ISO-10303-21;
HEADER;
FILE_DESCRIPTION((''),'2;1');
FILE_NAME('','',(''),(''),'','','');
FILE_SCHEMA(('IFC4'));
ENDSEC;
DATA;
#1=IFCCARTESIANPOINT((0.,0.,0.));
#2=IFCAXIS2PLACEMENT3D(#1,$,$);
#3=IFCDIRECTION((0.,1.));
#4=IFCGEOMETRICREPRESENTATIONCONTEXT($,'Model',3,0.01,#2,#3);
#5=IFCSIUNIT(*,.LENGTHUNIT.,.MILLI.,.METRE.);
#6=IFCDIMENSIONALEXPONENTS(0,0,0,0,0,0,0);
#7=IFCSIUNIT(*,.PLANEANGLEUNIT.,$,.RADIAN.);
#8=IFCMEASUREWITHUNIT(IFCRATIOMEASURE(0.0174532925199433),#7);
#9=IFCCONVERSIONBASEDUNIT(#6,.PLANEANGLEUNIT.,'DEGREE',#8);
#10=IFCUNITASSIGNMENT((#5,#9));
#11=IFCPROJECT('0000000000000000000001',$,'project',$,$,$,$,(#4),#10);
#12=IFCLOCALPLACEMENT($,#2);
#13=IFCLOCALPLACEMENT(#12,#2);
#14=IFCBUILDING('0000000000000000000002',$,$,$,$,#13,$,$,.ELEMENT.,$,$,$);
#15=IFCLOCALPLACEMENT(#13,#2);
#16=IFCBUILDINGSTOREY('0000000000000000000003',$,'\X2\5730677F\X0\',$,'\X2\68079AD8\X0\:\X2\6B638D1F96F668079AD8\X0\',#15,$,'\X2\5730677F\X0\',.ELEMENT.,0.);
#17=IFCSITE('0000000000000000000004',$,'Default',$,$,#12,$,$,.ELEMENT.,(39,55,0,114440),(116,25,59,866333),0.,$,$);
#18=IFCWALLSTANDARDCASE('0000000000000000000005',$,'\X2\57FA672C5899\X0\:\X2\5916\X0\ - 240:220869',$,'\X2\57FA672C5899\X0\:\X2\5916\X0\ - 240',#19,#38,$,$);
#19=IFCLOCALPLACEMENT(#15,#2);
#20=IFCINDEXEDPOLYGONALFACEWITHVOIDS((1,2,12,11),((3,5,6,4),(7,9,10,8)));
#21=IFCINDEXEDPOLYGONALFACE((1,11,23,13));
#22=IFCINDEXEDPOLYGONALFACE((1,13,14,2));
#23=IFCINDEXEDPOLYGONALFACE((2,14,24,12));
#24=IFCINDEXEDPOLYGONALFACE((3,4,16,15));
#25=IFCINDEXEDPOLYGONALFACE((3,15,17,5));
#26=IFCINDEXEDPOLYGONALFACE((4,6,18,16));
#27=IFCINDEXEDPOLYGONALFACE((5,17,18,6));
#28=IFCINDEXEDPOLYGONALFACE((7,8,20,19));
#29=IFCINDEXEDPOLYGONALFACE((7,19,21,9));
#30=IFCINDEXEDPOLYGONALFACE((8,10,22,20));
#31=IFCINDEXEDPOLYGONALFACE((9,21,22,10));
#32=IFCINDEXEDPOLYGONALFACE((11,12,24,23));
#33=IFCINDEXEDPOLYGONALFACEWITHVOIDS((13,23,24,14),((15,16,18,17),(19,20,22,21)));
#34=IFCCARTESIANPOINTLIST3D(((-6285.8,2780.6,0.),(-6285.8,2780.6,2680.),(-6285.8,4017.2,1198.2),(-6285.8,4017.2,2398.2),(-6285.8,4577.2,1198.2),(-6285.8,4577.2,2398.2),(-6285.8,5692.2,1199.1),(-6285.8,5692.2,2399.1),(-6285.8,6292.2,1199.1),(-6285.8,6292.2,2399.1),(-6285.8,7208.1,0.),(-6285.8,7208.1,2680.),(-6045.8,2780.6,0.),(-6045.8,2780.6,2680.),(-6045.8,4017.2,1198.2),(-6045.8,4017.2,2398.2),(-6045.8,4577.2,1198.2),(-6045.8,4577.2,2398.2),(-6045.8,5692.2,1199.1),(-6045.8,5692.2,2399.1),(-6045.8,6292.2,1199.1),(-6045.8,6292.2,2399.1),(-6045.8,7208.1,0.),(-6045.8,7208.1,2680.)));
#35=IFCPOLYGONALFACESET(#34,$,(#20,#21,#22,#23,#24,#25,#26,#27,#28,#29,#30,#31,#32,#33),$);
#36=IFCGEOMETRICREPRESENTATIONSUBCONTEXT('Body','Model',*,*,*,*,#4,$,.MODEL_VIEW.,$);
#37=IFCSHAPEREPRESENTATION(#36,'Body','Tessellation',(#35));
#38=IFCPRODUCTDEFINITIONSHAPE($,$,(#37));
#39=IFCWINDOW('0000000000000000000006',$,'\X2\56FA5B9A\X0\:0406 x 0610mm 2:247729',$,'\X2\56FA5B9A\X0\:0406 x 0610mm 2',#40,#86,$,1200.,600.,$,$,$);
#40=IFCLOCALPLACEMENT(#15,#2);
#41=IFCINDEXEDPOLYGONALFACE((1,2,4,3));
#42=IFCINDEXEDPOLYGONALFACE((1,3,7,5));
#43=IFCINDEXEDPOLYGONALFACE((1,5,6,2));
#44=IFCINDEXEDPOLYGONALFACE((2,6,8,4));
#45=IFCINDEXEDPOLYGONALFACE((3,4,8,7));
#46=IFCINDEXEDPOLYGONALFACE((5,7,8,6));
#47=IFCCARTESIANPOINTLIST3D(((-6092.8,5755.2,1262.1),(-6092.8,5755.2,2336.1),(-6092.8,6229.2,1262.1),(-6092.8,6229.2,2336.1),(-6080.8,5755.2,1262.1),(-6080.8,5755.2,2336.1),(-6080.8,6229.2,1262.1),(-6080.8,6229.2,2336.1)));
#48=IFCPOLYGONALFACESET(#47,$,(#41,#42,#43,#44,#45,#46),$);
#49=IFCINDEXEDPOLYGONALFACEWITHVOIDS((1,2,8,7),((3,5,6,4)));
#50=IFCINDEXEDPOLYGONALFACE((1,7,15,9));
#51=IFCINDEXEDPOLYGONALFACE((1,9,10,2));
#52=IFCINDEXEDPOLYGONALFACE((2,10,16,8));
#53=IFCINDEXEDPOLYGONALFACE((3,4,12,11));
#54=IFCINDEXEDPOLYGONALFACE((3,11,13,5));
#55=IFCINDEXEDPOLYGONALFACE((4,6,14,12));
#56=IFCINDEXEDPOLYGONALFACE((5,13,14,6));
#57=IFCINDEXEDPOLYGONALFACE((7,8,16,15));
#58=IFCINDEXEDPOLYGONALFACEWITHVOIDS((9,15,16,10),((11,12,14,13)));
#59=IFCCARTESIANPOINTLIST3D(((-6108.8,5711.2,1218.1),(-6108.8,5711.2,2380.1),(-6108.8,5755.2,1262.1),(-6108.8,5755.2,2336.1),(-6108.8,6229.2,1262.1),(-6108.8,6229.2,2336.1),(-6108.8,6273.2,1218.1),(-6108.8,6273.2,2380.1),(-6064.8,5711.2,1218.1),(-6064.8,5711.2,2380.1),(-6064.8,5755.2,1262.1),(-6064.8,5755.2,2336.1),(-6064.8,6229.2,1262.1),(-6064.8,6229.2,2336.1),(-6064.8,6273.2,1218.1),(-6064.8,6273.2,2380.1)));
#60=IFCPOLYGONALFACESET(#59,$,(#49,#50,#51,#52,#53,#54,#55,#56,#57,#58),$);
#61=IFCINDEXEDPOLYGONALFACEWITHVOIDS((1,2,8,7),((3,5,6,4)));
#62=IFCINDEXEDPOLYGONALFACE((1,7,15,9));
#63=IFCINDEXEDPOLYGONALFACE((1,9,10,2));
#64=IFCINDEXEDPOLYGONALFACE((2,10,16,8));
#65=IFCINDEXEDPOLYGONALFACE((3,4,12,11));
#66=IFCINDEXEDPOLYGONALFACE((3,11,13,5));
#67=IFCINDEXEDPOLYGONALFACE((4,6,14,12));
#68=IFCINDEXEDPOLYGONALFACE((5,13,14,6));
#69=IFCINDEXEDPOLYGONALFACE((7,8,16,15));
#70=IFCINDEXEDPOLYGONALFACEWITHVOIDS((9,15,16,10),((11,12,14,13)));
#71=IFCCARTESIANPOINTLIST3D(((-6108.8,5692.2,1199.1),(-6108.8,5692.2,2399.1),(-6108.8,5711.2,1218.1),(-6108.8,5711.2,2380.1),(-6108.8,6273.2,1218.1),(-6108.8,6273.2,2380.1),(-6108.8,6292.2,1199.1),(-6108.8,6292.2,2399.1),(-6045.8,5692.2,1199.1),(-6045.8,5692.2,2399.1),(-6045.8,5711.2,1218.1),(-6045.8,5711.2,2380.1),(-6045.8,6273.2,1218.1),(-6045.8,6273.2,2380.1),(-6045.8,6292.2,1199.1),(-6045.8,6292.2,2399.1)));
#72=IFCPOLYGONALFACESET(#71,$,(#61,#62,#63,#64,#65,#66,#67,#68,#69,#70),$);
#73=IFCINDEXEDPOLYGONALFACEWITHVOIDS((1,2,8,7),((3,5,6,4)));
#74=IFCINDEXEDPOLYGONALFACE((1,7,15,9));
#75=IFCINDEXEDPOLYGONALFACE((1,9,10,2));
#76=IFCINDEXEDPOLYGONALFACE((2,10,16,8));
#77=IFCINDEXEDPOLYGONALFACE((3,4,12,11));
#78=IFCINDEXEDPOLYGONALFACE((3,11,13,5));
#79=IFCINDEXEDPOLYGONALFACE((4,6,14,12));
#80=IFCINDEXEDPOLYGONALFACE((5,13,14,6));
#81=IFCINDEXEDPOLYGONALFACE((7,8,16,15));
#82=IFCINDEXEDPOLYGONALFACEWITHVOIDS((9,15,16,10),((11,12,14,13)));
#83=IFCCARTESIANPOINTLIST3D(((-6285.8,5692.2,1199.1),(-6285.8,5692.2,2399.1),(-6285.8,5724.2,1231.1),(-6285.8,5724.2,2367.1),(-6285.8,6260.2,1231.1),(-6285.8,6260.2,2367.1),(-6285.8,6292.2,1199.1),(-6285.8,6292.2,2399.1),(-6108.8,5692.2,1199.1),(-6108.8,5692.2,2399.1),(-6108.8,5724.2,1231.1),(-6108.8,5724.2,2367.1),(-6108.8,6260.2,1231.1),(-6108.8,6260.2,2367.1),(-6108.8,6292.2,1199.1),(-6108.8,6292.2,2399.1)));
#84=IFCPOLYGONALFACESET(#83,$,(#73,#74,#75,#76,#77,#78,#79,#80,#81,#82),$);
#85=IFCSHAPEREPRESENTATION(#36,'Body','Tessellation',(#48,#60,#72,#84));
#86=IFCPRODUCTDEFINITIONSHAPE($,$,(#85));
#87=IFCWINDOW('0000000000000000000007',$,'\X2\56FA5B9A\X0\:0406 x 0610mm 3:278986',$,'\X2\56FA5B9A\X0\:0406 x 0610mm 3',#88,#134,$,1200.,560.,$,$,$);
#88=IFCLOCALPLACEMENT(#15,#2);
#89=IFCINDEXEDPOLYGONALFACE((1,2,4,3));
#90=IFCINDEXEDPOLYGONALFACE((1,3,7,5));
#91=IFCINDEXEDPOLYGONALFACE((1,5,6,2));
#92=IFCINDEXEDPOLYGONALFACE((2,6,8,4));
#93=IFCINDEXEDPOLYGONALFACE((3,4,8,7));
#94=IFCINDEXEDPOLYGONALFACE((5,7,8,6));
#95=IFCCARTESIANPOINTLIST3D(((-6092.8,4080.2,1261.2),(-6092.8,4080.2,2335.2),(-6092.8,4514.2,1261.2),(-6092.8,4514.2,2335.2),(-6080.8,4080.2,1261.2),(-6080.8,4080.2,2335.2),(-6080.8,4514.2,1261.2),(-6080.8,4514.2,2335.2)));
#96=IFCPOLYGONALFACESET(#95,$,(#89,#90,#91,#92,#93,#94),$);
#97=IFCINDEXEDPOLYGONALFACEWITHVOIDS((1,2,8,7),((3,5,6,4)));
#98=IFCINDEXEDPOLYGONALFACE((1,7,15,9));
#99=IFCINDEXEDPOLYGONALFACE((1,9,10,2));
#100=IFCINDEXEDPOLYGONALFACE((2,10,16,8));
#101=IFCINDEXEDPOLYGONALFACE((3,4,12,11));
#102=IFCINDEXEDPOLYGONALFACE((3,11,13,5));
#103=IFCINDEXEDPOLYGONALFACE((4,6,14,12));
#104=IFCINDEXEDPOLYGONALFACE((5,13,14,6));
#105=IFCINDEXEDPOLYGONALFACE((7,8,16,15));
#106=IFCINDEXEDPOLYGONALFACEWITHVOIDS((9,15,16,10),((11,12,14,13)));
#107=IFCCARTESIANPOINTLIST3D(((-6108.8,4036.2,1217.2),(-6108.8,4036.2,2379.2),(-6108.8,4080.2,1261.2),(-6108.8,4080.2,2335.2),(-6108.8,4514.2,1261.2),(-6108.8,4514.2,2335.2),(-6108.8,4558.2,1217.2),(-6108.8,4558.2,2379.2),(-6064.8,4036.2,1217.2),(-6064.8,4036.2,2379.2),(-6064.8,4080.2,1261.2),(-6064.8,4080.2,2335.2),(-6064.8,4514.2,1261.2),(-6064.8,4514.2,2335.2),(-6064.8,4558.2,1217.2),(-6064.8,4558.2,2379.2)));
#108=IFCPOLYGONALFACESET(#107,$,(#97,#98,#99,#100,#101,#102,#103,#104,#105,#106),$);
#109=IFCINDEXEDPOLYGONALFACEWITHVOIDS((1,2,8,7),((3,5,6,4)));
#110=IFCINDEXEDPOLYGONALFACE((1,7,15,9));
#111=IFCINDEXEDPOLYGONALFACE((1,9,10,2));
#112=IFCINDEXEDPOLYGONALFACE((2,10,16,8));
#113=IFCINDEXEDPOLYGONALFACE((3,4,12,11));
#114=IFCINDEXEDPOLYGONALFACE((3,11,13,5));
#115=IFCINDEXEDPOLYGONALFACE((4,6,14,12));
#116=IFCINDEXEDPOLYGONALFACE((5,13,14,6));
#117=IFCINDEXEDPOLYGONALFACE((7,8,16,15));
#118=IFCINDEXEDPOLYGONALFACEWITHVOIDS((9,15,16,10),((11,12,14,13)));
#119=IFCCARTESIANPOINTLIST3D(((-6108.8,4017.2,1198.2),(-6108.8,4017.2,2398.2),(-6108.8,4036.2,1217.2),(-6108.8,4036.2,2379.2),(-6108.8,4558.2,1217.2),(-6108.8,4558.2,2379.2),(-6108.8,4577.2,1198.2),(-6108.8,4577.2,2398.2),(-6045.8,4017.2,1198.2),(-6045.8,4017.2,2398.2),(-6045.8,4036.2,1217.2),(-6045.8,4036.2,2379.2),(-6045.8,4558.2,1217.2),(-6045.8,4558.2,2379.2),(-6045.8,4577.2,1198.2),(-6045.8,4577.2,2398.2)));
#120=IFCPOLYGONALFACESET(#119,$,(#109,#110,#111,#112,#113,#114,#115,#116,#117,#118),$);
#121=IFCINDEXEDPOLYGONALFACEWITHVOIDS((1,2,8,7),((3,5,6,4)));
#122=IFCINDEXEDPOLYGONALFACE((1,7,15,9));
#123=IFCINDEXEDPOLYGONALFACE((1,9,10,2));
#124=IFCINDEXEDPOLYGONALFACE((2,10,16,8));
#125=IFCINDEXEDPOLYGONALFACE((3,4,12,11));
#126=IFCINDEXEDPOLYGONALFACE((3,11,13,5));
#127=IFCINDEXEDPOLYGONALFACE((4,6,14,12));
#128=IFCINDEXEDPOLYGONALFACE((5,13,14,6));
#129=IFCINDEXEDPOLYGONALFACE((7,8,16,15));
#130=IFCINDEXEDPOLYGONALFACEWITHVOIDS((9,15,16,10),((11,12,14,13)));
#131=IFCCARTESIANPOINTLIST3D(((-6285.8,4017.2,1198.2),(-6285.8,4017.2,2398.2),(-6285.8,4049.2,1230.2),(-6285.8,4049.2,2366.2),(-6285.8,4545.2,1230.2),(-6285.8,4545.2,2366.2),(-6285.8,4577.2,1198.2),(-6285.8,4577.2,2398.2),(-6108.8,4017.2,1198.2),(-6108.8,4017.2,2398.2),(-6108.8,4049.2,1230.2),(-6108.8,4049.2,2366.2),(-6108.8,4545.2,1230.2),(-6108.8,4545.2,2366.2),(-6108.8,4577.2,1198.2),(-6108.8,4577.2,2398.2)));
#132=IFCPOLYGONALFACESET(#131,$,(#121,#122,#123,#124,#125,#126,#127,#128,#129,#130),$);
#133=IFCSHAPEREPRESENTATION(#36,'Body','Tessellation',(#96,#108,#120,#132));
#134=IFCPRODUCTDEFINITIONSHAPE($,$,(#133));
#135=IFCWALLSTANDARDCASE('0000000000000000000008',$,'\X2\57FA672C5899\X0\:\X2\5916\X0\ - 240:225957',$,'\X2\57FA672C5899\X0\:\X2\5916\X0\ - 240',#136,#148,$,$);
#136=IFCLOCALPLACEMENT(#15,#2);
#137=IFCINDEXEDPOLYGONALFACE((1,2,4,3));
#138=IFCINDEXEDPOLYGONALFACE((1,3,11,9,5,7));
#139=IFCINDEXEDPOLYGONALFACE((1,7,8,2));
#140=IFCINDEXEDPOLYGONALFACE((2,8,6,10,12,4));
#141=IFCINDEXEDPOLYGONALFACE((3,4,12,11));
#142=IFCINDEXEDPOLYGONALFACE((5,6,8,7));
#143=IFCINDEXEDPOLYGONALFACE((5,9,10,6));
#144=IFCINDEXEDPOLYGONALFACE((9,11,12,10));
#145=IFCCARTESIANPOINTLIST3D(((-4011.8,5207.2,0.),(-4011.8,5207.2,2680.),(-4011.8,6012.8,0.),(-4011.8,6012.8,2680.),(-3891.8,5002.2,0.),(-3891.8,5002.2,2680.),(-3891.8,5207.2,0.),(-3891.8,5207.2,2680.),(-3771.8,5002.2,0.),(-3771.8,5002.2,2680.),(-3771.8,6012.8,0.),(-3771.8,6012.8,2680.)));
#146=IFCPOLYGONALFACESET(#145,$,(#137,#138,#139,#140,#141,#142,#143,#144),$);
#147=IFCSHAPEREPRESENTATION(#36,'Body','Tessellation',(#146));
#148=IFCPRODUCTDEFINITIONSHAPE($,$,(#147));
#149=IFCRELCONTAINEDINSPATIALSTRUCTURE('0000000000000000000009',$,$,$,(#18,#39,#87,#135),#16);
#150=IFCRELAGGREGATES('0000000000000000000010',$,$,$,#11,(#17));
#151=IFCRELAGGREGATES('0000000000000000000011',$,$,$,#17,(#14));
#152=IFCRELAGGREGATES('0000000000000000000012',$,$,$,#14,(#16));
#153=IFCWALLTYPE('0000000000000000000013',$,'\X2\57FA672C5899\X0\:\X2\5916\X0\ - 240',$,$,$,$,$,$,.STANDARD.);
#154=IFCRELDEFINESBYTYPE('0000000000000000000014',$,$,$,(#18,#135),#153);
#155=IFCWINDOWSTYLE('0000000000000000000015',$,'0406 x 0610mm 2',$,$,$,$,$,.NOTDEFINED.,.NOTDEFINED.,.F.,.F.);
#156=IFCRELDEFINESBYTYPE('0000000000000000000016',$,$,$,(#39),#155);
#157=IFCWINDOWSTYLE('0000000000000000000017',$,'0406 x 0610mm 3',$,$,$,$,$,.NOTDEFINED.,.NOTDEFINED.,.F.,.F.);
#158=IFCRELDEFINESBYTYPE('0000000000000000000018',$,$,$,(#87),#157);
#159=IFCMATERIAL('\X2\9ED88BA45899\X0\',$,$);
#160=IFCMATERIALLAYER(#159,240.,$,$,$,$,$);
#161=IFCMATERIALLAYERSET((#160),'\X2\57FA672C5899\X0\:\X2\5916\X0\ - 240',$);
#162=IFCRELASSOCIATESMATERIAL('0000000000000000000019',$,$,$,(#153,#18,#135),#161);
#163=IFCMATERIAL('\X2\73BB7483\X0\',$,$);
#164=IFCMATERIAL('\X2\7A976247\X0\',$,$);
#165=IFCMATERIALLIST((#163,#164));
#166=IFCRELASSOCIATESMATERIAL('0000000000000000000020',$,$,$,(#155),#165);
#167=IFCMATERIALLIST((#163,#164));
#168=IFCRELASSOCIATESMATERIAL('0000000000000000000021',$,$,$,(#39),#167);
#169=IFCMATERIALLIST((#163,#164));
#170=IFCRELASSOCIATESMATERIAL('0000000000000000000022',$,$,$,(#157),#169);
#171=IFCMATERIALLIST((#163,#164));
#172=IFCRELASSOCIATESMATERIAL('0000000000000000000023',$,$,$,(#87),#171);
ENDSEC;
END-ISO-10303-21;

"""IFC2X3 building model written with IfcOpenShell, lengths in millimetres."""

from ifc_helpers import new_model, entity, si_unit, converted_unit, direction, frame, frame_2d, origin, place, context, subcontext, project, spatial, polyline, rectangle, outline, extrude, source, transform, mapped, material, material_list, layer, layer_set, layer_usage, type_object, type_shapes, element, fill, save


model = new_model("IFC2X3")

# Units and contexts
model_context = context("Model", 3, precision=0.01, world=origin(), true_north=direction((0.0, 1.0)))
body_context = subcontext(model_context, "Body", "Model", "MODEL_VIEW")
ifc_project = project(units=[si_unit("LENGTHUNIT", "METRE", prefix="MILLI"), converted_unit("PLANEANGLEUNIT", "DEGREE", entity("IfcRatioMeasure", 0.0174532925199433), si_unit("PLANEANGLEUNIT", "RADIAN"), dimensions=[0, 0, 0, 0, 0, 0, 0])], contexts=[model_context])

# Site, building, storey
site_placement = place(None, origin())
site = spatial("IfcSite", under=ifc_project, at=site_placement, Name="Default", CompositionType="ELEMENT", RefLatitude=(39, 55, 0, 114440), RefLongitude=(116, 25, 59, 866333), RefElevation=0.0)
building_placement = place(site_placement, origin())
building = spatial("IfcBuilding", under=site, at=building_placement, CompositionType="ELEMENT")
storey_placement = place(building_placement, origin())
storey = spatial("IfcBuildingStorey", under=building, at=storey_placement, Name="地板", ObjectType="标高:正负零标高", LongName="地板", CompositionType="ELEMENT", Elevation=0.0)

# Wall, openings, windows
ifc_material_1 = material(Name="默认墙")
ifc_layer_1 = layer(ifc_material_1, 240.0)
ifc_layer_set_1 = layer_set([ifc_layer_1], Name="基本墙:外 - 240")
wall_type_1 = type_object("IfcWallType", Name="基本墙:外 - 240", PredefinedType="STANDARD", material=ifc_layer_set_1)
ifc_material_2 = material(Name="玻璃")
ifc_material_3 = material(Name="窗扇")
ifc_layer_usage_1 = layer_usage(ifc_layer_set_1, "AXIS2", "NEGATIVE", 120.0)
wall_1_placement = place(storey_placement, frame((-6165.8, 7208.1, 0.0), z_axis=(0.0, 0.0, 1.0), x_axis=(0.0, -1.0, 0.0)))
wall_1 = element("IfcWallStandardCase", 1, at=wall_1_placement, inside=storey, type_object=wall_type_1, material=ifc_layer_usage_1, Name="基本墙:外 - 240:220869", ObjectType="基本墙:外 - 240", context=body_context, shape_type="SweptSolid", body=[
    extrude(rectangle(XDim=4427.5, YDim=240.0, at=frame_2d((2213.8, 0.0), x_axis=(-1.0, 0.0))), origin(), (0.0, 0.0, 1.0), 2680.0),
])
opening_1_placement = place(wall_1_placement, frame((915.9, -120.0, 1199.1)))
opening_1 = element("IfcOpeningElement", 2, at=opening_1_placement, cuts=wall_1, ObjectType="Opening", context=body_context, shape_type="SweptSolid", body=[
    extrude(rectangle(XDim=1200.0, YDim=600.0, at=frame_2d((600.0, 300.0), x_axis=(1.0, 0.0))), frame((0.0, 0.0, 0.0), z_axis=(0.0, 1.0, 0.0), x_axis=(0.0, 0.0, 1.0)), (0.0, 0.0, 1.0), 240.0),
])
opening_2_placement = place(wall_1_placement, frame((2630.9, -120.0, 1198.2)))
opening_2 = element("IfcOpeningElement", 3, at=opening_2_placement, cuts=wall_1, ObjectType="Opening", context=body_context, shape_type="SweptSolid", body=[
    extrude(rectangle(XDim=1200.0, YDim=560.0, at=frame_2d((600.0, 280.0), x_axis=(1.0, 0.0))), frame((0.0, 0.0, 0.0), z_axis=(0.0, 1.0, 0.0), x_axis=(0.0, 0.0, 1.0)), (0.0, 0.0, 1.0), 240.0),
])
ifc_material_list_1 = material_list([ifc_material_2, ifc_material_3])
ifc_material_list_2 = material_list([ifc_material_2, ifc_material_3])
window_style_1 = type_object("IfcWindowStyle", Name="0406 x 0610mm 2", ConstructionType="NOTDEFINED", OperationType="NOTDEFINED", ParameterTakesPrecedence=False, Sizeable=False, material=ifc_material_list_2)
shared_shape_1 = source(origin(), body_context, "Body", "SweptSolid", [
    extrude(rectangle(XDim=12.0, YDim=474.0, at=frame_2d((0.0, 0.0), x_axis=(1.0, 0.0))), frame((300.0, 199.0, 63.0), z_axis=(0.0, 0.0, 1.0), x_axis=(0.0, -1.0, 0.0)), (0.0, 0.0, 1.0), 1074.0),
    extrude(outline(polyline([(-281.0, -581.0), (281.0, -581.0), (281.0, 581.0), (-281.0, 581.0), (-281.0, -581.0)]), holes=[polyline([(-237.0, -537.0), (-237.0, 537.0), (237.0, 537.0), (237.0, -537.0), (-237.0, -537.0)])]), frame((300.0, 177.0, 600.0), z_axis=(0.0, 1.0, 0.0), x_axis=(1.0, 0.0, 0.0)), (0.0, 0.0, 1.0), 44.0),
    extrude(outline(polyline([(-300.0, -600.0), (300.0, -600.0), (300.0, 600.0), (-300.0, 600.0), (-300.0, -600.0)]), holes=[polyline([(-281.0, -581.0), (-281.0, 581.0), (281.0, 581.0), (281.0, -581.0), (-281.0, -581.0)])]), frame((300.0, 177.0, 600.0), z_axis=(0.0, 1.0, 0.0), x_axis=(1.0, 0.0, 0.0)), (0.0, 0.0, 1.0), 63.0),
    extrude(outline(polyline([(-300.0, -600.0), (300.0, -600.0), (300.0, 600.0), (-300.0, 600.0), (-300.0, -600.0)]), holes=[polyline([(-268.0, -568.0), (-268.0, 568.0), (268.0, 568.0), (268.0, -568.0), (-268.0, -568.0)])]), frame((300.0, 0.0, 600.0), z_axis=(0.0, 1.0, 0.0), x_axis=(1.0, 0.0, 0.0)), (0.0, 0.0, 1.0), 177.0),
])
type_shapes(window_style_1, [shared_shape_1])
window_1_placement = place(opening_1_placement, origin())
window_1 = element("IfcWindow", 4, at=window_1_placement, inside=storey, type_object=window_style_1, material=ifc_material_list_1, Name="固定:0406 x 0610mm 2:247729", ObjectType="固定:0406 x 0610mm 2", OverallHeight=1200.0, OverallWidth=600.0, context=body_context, shape_type="MappedRepresentation", body=[
    mapped(shared_shape_1, transform((0.0, 0.0, 0.0), scale=1.0)),
])
fill(opening_1, window_1)
ifc_material_list_3 = material_list([ifc_material_2, ifc_material_3])
ifc_material_list_4 = material_list([ifc_material_2, ifc_material_3])
window_style_2 = type_object("IfcWindowStyle", Name="0406 x 0610mm 3", ConstructionType="NOTDEFINED", OperationType="NOTDEFINED", ParameterTakesPrecedence=False, Sizeable=False, material=ifc_material_list_4)
shared_shape_2 = source(origin(), body_context, "Body", "SweptSolid", [
    extrude(rectangle(XDim=12.0, YDim=434.0, at=frame_2d((0.0, 0.0), x_axis=(1.0, 0.0))), frame((280.0, 199.0, 63.0), z_axis=(0.0, 0.0, 1.0), x_axis=(0.0, -1.0, 0.0)), (0.0, 0.0, 1.0), 1074.0),
    extrude(outline(polyline([(-261.0, -581.0), (261.0, -581.0), (261.0, 581.0), (-261.0, 581.0), (-261.0, -581.0)]), holes=[polyline([(-217.0, -537.0), (-217.0, 537.0), (217.0, 537.0), (217.0, -537.0), (-217.0, -537.0)])]), frame((280.0, 177.0, 600.0), z_axis=(0.0, 1.0, 0.0), x_axis=(1.0, 0.0, 0.0)), (0.0, 0.0, 1.0), 44.0),
    extrude(outline(polyline([(-280.0, -600.0), (280.0, -600.0), (280.0, 600.0), (-280.0, 600.0), (-280.0, -600.0)]), holes=[polyline([(-261.0, -581.0), (-261.0, 581.0), (261.0, 581.0), (261.0, -581.0), (-261.0, -581.0)])]), frame((280.0, 177.0, 600.0), z_axis=(0.0, 1.0, 0.0), x_axis=(1.0, 0.0, 0.0)), (0.0, 0.0, 1.0), 63.0),
    extrude(outline(polyline([(-280.0, -600.0), (280.0, -600.0), (280.0, 600.0), (-280.0, 600.0), (-280.0, -600.0)]), holes=[polyline([(-248.0, -568.0), (-248.0, 568.0), (248.0, 568.0), (248.0, -568.0), (-248.0, -568.0)])]), frame((280.0, 0.0, 600.0), z_axis=(0.0, 1.0, 0.0), x_axis=(1.0, 0.0, 0.0)), (0.0, 0.0, 1.0), 177.0),
])
type_shapes(window_style_2, [shared_shape_2])
window_2_placement = place(opening_2_placement, origin())
window_2 = element("IfcWindow", 5, at=window_2_placement, inside=storey, type_object=window_style_2, material=ifc_material_list_3, Name="固定:0406 x 0610mm 3:278986", ObjectType="固定:0406 x 0610mm 3", OverallHeight=1200.0, OverallWidth=560.0, context=body_context, shape_type="MappedRepresentation", body=[
    mapped(shared_shape_2, transform((0.0, 0.0, 0.0), scale=1.0)),
])
fill(opening_2, window_2)

# Wall
ifc_layer_usage_2 = layer_usage(ifc_layer_set_1, "AXIS2", "NEGATIVE", 120.0)
wall_2_placement = place(storey_placement, frame((-3891.8, 6012.8, 0.0), z_axis=(0.0, 0.0, 1.0), x_axis=(0.0, -1.0, 0.0)))
element("IfcWallStandardCase", 6, at=wall_2_placement, inside=storey, type_object=wall_type_1, material=ifc_layer_usage_2, Name="基本墙:外 - 240:225957", ObjectType="基本墙:外 - 240", context=body_context, shape_type="SweptSolid", body=[
    extrude(outline(polyline([(805.6, -120.0), (805.6, 0.0), (1010.6, 0.0), (1010.6, 120.0), (0.0, 120.0), (0.0, -120.0), (805.6, -120.0)])), origin(), (0.0, 0.0, 1.0), 2680.0),
])

save(model, "model.ifc")
